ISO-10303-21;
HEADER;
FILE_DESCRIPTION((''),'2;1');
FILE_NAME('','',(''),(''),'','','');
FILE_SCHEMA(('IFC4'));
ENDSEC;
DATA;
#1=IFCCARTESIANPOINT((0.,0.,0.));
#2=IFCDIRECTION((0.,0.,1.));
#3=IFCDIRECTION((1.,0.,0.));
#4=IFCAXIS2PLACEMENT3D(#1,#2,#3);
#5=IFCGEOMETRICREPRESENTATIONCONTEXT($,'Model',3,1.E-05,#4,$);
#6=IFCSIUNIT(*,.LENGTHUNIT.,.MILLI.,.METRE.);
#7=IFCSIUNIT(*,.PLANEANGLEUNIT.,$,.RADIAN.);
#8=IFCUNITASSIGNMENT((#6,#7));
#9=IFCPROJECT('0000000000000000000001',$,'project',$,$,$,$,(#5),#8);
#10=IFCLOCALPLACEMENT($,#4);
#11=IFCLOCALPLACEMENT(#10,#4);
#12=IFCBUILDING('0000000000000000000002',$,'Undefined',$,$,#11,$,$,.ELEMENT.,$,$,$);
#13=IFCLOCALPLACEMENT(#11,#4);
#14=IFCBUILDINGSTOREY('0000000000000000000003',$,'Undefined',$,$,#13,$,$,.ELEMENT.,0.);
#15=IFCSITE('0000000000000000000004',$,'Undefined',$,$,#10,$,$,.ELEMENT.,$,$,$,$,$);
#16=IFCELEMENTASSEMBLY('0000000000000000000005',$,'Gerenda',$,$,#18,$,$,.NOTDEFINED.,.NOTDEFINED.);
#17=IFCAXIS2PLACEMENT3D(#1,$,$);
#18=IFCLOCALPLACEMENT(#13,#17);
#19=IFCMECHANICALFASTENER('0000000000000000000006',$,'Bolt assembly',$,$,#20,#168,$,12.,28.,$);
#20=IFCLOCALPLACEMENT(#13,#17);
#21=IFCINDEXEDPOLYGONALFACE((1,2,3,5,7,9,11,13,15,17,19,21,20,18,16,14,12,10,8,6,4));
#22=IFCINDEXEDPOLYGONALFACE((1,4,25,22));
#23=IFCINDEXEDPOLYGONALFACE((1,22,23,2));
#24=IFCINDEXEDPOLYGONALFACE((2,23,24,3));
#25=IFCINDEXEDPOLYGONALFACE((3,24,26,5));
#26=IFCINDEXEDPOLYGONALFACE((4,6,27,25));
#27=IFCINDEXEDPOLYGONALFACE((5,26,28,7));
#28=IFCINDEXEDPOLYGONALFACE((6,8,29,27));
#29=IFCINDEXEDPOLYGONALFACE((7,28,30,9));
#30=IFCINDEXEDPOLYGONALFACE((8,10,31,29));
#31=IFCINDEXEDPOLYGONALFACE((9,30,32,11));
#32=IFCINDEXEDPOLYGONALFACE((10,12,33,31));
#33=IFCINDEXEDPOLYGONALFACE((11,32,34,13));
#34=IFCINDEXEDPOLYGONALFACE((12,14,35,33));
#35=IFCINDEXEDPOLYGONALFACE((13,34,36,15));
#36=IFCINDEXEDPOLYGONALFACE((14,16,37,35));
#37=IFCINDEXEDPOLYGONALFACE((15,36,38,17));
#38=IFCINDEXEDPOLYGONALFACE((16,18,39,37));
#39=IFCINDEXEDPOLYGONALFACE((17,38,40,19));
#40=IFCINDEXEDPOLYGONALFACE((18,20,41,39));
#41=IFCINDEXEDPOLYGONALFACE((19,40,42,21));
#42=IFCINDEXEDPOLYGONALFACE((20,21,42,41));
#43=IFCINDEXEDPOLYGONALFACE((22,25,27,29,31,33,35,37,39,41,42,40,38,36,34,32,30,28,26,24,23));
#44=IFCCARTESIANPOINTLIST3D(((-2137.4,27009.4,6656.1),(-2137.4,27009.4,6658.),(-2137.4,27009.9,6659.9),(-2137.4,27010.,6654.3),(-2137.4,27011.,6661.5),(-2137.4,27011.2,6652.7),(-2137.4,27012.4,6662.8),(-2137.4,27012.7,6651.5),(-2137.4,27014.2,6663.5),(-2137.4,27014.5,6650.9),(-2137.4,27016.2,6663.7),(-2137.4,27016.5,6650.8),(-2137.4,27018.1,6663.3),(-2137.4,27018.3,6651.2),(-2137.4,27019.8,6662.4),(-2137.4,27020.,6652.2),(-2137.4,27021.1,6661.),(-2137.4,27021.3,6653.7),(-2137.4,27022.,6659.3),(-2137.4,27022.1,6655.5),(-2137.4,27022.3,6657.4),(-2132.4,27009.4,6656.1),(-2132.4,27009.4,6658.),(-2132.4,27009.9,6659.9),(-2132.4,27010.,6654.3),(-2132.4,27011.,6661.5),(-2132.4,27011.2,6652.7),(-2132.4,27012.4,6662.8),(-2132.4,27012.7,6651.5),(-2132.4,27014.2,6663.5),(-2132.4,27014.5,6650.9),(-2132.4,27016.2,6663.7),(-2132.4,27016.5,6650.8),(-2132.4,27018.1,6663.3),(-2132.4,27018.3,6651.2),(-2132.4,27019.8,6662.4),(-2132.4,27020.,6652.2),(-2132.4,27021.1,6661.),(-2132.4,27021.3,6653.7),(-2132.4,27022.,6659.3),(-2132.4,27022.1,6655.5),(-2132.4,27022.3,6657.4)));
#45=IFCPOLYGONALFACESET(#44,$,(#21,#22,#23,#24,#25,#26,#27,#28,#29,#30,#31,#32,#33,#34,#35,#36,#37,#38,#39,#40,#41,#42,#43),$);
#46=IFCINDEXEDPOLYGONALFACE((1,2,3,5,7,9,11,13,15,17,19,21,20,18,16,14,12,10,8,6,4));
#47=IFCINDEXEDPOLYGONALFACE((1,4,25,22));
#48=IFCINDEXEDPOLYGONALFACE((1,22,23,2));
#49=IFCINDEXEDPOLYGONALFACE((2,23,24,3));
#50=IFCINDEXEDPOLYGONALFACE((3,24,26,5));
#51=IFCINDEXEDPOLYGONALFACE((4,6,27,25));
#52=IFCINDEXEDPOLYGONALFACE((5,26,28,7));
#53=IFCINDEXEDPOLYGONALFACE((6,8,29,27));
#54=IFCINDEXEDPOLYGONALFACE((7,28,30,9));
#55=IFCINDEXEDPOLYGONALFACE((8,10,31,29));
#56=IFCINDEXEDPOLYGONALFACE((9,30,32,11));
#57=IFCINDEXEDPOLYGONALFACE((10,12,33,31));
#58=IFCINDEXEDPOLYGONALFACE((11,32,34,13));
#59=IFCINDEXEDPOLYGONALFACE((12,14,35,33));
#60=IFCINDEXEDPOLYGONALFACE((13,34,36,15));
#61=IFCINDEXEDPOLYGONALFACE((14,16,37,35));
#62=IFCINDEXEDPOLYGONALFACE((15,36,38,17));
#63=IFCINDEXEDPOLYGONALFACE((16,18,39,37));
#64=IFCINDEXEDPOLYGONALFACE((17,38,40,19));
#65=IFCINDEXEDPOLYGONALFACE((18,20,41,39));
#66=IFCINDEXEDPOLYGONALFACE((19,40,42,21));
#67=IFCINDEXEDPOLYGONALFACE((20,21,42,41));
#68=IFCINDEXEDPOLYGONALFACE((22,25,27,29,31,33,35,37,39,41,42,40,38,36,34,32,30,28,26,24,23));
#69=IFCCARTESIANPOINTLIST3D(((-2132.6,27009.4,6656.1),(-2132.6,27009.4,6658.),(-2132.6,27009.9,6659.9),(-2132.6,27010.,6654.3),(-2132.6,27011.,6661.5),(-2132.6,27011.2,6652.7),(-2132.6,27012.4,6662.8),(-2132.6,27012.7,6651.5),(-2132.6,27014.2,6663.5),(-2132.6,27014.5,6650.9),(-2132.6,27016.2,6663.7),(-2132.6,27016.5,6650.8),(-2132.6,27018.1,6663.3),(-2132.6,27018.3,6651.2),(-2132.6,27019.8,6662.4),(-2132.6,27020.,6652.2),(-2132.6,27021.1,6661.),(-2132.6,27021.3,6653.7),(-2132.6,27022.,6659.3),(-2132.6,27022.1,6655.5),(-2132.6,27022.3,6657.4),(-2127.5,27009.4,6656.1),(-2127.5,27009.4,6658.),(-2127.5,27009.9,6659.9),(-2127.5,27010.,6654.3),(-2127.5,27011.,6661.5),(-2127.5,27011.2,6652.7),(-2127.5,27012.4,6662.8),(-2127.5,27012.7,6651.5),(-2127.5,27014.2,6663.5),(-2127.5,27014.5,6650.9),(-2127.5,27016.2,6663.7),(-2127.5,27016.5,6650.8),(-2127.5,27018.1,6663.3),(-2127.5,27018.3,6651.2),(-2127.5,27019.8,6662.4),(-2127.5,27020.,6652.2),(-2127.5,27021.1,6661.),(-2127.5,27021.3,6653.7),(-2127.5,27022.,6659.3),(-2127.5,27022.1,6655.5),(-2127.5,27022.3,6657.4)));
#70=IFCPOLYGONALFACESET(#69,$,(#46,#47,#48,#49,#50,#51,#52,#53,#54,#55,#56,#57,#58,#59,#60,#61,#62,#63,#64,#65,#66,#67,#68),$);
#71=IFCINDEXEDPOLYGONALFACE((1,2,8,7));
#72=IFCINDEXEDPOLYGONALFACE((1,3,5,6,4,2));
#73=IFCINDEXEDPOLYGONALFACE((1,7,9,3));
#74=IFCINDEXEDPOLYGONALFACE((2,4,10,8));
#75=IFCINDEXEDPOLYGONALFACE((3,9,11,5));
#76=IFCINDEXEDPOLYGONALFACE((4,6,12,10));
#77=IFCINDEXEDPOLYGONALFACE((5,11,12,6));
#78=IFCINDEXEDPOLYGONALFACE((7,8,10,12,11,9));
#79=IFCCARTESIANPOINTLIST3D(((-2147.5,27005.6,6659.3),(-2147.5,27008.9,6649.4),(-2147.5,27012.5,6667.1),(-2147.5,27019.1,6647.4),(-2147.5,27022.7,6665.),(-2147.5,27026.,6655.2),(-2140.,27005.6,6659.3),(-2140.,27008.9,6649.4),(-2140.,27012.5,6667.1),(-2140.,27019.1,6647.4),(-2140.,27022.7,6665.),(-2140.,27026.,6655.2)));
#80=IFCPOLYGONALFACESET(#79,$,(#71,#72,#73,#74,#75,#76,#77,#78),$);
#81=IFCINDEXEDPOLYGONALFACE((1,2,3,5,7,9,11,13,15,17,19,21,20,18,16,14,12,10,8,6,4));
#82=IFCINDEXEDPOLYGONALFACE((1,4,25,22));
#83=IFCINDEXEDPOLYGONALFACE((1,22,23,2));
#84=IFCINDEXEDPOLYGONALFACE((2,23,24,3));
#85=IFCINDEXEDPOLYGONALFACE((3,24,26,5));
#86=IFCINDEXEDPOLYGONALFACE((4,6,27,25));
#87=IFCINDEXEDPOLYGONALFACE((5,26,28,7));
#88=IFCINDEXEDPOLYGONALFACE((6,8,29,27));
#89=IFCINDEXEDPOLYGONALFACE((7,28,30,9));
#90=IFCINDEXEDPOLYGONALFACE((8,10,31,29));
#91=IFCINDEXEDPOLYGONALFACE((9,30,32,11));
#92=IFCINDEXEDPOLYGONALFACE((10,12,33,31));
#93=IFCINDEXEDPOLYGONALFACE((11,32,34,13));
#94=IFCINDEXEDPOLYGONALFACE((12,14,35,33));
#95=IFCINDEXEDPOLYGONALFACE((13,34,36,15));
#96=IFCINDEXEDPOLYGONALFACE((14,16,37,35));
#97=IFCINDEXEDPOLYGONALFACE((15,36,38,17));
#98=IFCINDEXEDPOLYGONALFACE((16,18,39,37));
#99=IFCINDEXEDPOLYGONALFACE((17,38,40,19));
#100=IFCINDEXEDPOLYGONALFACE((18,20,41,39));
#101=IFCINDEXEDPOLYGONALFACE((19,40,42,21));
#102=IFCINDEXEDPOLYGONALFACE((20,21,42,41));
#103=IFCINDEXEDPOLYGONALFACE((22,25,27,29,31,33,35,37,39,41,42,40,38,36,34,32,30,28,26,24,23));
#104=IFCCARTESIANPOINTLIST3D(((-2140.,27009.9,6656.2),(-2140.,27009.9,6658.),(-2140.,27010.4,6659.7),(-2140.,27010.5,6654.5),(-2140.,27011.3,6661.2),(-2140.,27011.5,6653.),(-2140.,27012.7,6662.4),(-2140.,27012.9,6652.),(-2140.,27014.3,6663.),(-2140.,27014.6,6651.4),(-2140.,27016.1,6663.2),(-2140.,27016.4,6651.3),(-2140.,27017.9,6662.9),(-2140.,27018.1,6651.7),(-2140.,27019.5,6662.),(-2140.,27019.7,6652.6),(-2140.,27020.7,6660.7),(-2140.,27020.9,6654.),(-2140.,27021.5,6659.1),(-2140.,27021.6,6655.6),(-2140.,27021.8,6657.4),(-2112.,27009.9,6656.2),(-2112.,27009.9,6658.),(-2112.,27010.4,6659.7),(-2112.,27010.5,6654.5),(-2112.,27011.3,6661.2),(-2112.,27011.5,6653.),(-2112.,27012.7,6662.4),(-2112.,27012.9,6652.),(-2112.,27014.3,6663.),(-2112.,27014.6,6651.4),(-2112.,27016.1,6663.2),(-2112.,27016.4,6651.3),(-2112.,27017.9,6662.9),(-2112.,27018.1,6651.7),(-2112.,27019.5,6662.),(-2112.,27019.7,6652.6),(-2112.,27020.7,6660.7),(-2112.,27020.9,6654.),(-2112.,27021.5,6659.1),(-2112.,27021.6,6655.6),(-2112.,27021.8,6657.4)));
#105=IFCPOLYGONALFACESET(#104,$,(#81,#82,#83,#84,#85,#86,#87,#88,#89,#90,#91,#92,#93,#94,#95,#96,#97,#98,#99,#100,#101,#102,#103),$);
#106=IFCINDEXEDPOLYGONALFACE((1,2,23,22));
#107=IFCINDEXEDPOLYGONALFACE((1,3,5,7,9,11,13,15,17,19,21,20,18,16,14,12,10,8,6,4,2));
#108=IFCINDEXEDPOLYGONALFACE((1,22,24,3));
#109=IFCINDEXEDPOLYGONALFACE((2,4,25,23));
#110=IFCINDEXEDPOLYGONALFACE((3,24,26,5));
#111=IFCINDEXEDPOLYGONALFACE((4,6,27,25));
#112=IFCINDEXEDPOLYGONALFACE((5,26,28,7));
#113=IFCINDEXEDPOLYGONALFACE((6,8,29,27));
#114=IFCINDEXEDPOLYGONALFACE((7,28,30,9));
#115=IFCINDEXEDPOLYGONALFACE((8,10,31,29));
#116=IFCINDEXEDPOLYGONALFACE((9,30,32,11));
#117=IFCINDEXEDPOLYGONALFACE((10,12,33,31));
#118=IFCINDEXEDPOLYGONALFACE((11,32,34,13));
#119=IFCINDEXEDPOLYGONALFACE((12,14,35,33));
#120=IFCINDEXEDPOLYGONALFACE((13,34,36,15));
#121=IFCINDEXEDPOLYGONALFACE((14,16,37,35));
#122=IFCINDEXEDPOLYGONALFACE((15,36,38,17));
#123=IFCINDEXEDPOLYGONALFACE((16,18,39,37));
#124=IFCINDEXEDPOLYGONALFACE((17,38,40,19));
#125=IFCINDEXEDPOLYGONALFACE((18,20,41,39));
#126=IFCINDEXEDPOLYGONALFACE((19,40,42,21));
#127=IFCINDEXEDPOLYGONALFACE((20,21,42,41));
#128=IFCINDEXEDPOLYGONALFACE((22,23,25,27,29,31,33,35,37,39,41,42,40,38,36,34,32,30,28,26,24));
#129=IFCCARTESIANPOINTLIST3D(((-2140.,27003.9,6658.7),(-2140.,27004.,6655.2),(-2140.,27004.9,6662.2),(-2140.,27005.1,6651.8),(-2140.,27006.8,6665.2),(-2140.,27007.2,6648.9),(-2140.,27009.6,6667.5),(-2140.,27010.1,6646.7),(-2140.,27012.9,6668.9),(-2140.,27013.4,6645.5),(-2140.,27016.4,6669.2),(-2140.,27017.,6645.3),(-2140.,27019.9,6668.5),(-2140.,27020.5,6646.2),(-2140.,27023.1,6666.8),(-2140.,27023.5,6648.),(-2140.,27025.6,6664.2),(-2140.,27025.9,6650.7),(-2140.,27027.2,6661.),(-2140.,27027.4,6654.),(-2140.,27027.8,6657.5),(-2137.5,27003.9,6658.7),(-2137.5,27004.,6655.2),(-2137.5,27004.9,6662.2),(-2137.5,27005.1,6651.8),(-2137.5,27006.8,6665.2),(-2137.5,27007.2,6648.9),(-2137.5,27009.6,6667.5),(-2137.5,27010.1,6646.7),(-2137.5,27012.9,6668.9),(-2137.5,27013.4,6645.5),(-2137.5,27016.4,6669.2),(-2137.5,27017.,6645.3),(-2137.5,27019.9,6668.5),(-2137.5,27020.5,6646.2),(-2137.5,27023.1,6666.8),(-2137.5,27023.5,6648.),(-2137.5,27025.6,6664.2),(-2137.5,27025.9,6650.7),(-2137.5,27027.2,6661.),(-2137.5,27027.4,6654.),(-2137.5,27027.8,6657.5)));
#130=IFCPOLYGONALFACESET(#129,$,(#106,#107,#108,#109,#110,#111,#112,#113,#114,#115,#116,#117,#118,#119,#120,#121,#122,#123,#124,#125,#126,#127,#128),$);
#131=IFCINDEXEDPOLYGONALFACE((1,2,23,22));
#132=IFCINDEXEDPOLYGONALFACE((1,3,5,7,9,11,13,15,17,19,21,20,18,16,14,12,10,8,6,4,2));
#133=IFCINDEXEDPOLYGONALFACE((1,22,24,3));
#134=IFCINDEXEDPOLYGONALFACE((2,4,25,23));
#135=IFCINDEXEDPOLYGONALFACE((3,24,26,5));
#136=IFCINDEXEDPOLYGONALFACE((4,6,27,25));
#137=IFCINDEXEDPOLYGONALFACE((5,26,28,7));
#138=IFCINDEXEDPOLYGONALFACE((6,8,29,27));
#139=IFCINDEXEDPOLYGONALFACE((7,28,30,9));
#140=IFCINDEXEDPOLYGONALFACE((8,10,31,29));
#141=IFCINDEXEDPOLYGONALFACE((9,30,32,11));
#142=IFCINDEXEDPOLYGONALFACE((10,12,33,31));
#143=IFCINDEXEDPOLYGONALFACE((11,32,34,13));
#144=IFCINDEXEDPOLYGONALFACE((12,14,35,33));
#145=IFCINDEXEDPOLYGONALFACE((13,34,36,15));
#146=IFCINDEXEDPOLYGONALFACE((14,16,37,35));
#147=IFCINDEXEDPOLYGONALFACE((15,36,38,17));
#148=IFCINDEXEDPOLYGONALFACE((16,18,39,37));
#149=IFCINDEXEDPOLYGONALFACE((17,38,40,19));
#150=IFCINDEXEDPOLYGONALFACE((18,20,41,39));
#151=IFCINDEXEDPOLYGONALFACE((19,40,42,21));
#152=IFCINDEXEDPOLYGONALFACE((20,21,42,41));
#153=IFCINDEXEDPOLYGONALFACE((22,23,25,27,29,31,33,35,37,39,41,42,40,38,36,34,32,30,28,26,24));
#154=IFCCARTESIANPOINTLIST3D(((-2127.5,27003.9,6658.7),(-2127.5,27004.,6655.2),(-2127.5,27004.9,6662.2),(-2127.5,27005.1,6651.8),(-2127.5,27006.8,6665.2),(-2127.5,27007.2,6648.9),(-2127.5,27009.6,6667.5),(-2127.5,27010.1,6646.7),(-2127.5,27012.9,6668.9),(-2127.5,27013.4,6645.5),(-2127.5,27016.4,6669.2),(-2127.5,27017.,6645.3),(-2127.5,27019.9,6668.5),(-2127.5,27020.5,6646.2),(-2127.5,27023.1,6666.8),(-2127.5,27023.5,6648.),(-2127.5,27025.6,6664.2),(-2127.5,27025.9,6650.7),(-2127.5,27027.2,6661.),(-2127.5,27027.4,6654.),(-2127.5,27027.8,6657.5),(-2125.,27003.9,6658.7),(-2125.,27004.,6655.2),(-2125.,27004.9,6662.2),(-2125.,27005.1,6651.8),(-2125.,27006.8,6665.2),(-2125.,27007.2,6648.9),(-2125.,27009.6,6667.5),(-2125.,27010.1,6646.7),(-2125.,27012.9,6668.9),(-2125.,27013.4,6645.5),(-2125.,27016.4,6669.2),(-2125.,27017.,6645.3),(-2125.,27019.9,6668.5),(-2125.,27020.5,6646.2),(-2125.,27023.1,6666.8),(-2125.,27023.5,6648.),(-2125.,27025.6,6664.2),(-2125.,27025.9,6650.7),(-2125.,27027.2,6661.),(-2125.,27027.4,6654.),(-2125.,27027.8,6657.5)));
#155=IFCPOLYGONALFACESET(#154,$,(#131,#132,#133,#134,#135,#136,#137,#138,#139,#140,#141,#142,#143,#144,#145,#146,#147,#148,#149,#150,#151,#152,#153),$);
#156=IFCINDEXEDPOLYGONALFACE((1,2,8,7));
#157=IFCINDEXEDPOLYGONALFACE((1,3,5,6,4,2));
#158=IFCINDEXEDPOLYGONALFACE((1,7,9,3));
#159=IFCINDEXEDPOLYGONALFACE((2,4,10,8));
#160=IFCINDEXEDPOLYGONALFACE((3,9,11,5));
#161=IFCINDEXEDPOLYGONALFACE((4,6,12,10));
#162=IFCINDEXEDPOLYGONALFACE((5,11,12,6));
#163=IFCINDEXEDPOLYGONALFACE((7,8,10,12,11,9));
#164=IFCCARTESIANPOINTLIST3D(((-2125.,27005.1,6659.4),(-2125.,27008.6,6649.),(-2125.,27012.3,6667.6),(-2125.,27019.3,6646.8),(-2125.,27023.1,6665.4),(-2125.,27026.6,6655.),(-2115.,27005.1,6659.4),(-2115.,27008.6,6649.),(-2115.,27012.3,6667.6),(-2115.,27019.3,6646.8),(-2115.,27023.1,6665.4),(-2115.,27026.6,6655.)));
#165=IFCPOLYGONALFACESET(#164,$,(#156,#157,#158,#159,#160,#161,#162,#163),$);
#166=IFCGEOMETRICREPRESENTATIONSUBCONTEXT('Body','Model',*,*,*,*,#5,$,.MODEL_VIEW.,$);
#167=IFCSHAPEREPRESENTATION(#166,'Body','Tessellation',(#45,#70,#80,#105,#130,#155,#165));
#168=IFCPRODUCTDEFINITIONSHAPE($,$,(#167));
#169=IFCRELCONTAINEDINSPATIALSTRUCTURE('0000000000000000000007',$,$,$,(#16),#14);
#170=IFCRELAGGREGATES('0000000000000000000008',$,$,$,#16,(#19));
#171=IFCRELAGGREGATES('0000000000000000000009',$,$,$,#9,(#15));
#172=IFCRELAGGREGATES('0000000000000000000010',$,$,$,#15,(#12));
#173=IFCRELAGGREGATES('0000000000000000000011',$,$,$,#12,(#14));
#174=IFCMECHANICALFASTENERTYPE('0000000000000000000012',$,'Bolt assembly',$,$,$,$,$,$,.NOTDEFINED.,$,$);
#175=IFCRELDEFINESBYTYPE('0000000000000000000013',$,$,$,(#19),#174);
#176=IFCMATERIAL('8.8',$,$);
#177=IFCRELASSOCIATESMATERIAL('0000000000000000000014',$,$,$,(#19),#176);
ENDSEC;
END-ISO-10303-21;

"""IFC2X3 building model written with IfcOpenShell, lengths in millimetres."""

from ifc_helpers import new_model, si_unit, frame, origin_with_axes, origin_2d_with_axis, place, context, subcontext, project, spatial, polyline, circle, outline, extrude, source, transform, mapped, material, type_object, element, aggregate, save


model = new_model("IFC2X3")

# Units and contexts
model_context = context("Model", 3, precision=1e-05, world=origin_with_axes())
body_context = subcontext(model_context, "Body", "Model", "MODEL_VIEW")
ifc_project = project(units=[si_unit("LENGTHUNIT", "METRE", prefix="MILLI"), si_unit("PLANEANGLEUNIT", "RADIAN")], contexts=[model_context])

# Site, building, storey
site_placement = place(None, origin_with_axes())
site = spatial("IfcSite", under=ifc_project, at=site_placement, Name="Undefined", CompositionType="ELEMENT")
building_placement = place(site_placement, origin_with_axes())
building = spatial("IfcBuilding", under=site, at=building_placement, Name="Undefined", CompositionType="ELEMENT")
storey_placement = place(building_placement, origin_with_axes())
storey = spatial("IfcBuildingStorey", under=building, at=storey_placement, Name="Undefined", CompositionType="ELEMENT", Elevation=0.0)

# Element assembly
assembly_1_placement = place(storey_placement, origin_with_axes())
assembly_1 = element("IfcElementAssembly", 1, at=assembly_1_placement, inside=storey, Name="Gerenda", AssemblyPlace="NOTDEFINED", PredefinedType="NOTDEFINED")

# Mechanical fastener
ifc_material_1 = material(Name="8.8")
mechanical_fastener_type = type_object("IfcMechanicalFastenerType", Name="Bolt assembly")
shared_shape_1 = source(origin_with_axes(), body_context, "Body", "SweptSolid", [
    extrude(circle(Radius=6.5, at=origin_2d_with_axis()), frame((0.0, -7.4, 0.0), z_axis=(0.0, 1.0, 0.0), x_axis=(1.0, 0.0, 0.0)), (0.0, 0.0, 1.0), 5.0),
    extrude(circle(Radius=6.5, at=origin_2d_with_axis()), frame((0.0, -2.6, 0.0), z_axis=(0.0, 1.0, 0.0), x_axis=(1.0, 0.0, 0.0)), (0.0, 0.0, 1.0), 5.1),
    extrude(outline(polyline([(9.0, -5.2), (9.0, 5.2), (0.0, 10.4), (-9.0, 5.2), (-9.0, -5.2), (0.0, -10.4), (9.0, -5.2)])), frame((0.0, -17.5, 0.0), z_axis=(0.0, 1.0, 0.0), x_axis=(1.0, 0.0, 0.0)), (0.0, 0.0, 1.0), 7.5),
    extrude(circle(Radius=6.0, at=origin_2d_with_axis()), frame((0.0, -10.0, 0.0), z_axis=(0.0, 1.0, 0.0), x_axis=(1.0, 0.0, 0.0)), (0.0, 0.0, 1.0), 28.0),
    extrude(circle(Radius=12.0, at=origin_2d_with_axis()), frame((0.0, -10.0, 0.0), z_axis=(0.0, 1.0, 0.0), x_axis=(1.0, 0.0, 0.0)), (0.0, 0.0, 1.0), 2.5),
    extrude(circle(Radius=12.0, at=origin_2d_with_axis()), frame((0.0, 2.5, 0.0), z_axis=(0.0, 1.0, 0.0), x_axis=(1.0, 0.0, 0.0)), (0.0, 0.0, 1.0), 2.5),
    extrude(outline(polyline([(9.5, -5.5), (9.5, 5.5), (0.0, 11.0), (-9.5, 5.5), (-9.5, -5.5), (0.0, -11.0), (9.5, -5.5)])), frame((0.0, 5.0, 0.0), z_axis=(0.0, 1.0, 0.0), x_axis=(1.0, 0.0, 0.0)), (0.0, 0.0, 1.0), 10.0),
])
mechanical_fastener_1_placement = place(assembly_1_placement, frame((-2130.0, 27015.8, 6657.2), z_axis=(0.0, 0.662403, 0.749147), x_axis=(-0.000003, -0.749147, 0.662403)))
mechanical_fastener_1 = element("IfcMechanicalFastener", 2, at=mechanical_fastener_1_placement, type_object=mechanical_fastener_type, material=ifc_material_1, Name="Bolt assembly", NominalDiameter=12.0, NominalLength=28.0, context=body_context, shape_type="MappedRepresentation", body=[
    mapped(shared_shape_1, transform((0.0, 0.0, 0.0))),
])
aggregate(assembly_1, [mechanical_fastener_1])

save(model, "model.ifc")
